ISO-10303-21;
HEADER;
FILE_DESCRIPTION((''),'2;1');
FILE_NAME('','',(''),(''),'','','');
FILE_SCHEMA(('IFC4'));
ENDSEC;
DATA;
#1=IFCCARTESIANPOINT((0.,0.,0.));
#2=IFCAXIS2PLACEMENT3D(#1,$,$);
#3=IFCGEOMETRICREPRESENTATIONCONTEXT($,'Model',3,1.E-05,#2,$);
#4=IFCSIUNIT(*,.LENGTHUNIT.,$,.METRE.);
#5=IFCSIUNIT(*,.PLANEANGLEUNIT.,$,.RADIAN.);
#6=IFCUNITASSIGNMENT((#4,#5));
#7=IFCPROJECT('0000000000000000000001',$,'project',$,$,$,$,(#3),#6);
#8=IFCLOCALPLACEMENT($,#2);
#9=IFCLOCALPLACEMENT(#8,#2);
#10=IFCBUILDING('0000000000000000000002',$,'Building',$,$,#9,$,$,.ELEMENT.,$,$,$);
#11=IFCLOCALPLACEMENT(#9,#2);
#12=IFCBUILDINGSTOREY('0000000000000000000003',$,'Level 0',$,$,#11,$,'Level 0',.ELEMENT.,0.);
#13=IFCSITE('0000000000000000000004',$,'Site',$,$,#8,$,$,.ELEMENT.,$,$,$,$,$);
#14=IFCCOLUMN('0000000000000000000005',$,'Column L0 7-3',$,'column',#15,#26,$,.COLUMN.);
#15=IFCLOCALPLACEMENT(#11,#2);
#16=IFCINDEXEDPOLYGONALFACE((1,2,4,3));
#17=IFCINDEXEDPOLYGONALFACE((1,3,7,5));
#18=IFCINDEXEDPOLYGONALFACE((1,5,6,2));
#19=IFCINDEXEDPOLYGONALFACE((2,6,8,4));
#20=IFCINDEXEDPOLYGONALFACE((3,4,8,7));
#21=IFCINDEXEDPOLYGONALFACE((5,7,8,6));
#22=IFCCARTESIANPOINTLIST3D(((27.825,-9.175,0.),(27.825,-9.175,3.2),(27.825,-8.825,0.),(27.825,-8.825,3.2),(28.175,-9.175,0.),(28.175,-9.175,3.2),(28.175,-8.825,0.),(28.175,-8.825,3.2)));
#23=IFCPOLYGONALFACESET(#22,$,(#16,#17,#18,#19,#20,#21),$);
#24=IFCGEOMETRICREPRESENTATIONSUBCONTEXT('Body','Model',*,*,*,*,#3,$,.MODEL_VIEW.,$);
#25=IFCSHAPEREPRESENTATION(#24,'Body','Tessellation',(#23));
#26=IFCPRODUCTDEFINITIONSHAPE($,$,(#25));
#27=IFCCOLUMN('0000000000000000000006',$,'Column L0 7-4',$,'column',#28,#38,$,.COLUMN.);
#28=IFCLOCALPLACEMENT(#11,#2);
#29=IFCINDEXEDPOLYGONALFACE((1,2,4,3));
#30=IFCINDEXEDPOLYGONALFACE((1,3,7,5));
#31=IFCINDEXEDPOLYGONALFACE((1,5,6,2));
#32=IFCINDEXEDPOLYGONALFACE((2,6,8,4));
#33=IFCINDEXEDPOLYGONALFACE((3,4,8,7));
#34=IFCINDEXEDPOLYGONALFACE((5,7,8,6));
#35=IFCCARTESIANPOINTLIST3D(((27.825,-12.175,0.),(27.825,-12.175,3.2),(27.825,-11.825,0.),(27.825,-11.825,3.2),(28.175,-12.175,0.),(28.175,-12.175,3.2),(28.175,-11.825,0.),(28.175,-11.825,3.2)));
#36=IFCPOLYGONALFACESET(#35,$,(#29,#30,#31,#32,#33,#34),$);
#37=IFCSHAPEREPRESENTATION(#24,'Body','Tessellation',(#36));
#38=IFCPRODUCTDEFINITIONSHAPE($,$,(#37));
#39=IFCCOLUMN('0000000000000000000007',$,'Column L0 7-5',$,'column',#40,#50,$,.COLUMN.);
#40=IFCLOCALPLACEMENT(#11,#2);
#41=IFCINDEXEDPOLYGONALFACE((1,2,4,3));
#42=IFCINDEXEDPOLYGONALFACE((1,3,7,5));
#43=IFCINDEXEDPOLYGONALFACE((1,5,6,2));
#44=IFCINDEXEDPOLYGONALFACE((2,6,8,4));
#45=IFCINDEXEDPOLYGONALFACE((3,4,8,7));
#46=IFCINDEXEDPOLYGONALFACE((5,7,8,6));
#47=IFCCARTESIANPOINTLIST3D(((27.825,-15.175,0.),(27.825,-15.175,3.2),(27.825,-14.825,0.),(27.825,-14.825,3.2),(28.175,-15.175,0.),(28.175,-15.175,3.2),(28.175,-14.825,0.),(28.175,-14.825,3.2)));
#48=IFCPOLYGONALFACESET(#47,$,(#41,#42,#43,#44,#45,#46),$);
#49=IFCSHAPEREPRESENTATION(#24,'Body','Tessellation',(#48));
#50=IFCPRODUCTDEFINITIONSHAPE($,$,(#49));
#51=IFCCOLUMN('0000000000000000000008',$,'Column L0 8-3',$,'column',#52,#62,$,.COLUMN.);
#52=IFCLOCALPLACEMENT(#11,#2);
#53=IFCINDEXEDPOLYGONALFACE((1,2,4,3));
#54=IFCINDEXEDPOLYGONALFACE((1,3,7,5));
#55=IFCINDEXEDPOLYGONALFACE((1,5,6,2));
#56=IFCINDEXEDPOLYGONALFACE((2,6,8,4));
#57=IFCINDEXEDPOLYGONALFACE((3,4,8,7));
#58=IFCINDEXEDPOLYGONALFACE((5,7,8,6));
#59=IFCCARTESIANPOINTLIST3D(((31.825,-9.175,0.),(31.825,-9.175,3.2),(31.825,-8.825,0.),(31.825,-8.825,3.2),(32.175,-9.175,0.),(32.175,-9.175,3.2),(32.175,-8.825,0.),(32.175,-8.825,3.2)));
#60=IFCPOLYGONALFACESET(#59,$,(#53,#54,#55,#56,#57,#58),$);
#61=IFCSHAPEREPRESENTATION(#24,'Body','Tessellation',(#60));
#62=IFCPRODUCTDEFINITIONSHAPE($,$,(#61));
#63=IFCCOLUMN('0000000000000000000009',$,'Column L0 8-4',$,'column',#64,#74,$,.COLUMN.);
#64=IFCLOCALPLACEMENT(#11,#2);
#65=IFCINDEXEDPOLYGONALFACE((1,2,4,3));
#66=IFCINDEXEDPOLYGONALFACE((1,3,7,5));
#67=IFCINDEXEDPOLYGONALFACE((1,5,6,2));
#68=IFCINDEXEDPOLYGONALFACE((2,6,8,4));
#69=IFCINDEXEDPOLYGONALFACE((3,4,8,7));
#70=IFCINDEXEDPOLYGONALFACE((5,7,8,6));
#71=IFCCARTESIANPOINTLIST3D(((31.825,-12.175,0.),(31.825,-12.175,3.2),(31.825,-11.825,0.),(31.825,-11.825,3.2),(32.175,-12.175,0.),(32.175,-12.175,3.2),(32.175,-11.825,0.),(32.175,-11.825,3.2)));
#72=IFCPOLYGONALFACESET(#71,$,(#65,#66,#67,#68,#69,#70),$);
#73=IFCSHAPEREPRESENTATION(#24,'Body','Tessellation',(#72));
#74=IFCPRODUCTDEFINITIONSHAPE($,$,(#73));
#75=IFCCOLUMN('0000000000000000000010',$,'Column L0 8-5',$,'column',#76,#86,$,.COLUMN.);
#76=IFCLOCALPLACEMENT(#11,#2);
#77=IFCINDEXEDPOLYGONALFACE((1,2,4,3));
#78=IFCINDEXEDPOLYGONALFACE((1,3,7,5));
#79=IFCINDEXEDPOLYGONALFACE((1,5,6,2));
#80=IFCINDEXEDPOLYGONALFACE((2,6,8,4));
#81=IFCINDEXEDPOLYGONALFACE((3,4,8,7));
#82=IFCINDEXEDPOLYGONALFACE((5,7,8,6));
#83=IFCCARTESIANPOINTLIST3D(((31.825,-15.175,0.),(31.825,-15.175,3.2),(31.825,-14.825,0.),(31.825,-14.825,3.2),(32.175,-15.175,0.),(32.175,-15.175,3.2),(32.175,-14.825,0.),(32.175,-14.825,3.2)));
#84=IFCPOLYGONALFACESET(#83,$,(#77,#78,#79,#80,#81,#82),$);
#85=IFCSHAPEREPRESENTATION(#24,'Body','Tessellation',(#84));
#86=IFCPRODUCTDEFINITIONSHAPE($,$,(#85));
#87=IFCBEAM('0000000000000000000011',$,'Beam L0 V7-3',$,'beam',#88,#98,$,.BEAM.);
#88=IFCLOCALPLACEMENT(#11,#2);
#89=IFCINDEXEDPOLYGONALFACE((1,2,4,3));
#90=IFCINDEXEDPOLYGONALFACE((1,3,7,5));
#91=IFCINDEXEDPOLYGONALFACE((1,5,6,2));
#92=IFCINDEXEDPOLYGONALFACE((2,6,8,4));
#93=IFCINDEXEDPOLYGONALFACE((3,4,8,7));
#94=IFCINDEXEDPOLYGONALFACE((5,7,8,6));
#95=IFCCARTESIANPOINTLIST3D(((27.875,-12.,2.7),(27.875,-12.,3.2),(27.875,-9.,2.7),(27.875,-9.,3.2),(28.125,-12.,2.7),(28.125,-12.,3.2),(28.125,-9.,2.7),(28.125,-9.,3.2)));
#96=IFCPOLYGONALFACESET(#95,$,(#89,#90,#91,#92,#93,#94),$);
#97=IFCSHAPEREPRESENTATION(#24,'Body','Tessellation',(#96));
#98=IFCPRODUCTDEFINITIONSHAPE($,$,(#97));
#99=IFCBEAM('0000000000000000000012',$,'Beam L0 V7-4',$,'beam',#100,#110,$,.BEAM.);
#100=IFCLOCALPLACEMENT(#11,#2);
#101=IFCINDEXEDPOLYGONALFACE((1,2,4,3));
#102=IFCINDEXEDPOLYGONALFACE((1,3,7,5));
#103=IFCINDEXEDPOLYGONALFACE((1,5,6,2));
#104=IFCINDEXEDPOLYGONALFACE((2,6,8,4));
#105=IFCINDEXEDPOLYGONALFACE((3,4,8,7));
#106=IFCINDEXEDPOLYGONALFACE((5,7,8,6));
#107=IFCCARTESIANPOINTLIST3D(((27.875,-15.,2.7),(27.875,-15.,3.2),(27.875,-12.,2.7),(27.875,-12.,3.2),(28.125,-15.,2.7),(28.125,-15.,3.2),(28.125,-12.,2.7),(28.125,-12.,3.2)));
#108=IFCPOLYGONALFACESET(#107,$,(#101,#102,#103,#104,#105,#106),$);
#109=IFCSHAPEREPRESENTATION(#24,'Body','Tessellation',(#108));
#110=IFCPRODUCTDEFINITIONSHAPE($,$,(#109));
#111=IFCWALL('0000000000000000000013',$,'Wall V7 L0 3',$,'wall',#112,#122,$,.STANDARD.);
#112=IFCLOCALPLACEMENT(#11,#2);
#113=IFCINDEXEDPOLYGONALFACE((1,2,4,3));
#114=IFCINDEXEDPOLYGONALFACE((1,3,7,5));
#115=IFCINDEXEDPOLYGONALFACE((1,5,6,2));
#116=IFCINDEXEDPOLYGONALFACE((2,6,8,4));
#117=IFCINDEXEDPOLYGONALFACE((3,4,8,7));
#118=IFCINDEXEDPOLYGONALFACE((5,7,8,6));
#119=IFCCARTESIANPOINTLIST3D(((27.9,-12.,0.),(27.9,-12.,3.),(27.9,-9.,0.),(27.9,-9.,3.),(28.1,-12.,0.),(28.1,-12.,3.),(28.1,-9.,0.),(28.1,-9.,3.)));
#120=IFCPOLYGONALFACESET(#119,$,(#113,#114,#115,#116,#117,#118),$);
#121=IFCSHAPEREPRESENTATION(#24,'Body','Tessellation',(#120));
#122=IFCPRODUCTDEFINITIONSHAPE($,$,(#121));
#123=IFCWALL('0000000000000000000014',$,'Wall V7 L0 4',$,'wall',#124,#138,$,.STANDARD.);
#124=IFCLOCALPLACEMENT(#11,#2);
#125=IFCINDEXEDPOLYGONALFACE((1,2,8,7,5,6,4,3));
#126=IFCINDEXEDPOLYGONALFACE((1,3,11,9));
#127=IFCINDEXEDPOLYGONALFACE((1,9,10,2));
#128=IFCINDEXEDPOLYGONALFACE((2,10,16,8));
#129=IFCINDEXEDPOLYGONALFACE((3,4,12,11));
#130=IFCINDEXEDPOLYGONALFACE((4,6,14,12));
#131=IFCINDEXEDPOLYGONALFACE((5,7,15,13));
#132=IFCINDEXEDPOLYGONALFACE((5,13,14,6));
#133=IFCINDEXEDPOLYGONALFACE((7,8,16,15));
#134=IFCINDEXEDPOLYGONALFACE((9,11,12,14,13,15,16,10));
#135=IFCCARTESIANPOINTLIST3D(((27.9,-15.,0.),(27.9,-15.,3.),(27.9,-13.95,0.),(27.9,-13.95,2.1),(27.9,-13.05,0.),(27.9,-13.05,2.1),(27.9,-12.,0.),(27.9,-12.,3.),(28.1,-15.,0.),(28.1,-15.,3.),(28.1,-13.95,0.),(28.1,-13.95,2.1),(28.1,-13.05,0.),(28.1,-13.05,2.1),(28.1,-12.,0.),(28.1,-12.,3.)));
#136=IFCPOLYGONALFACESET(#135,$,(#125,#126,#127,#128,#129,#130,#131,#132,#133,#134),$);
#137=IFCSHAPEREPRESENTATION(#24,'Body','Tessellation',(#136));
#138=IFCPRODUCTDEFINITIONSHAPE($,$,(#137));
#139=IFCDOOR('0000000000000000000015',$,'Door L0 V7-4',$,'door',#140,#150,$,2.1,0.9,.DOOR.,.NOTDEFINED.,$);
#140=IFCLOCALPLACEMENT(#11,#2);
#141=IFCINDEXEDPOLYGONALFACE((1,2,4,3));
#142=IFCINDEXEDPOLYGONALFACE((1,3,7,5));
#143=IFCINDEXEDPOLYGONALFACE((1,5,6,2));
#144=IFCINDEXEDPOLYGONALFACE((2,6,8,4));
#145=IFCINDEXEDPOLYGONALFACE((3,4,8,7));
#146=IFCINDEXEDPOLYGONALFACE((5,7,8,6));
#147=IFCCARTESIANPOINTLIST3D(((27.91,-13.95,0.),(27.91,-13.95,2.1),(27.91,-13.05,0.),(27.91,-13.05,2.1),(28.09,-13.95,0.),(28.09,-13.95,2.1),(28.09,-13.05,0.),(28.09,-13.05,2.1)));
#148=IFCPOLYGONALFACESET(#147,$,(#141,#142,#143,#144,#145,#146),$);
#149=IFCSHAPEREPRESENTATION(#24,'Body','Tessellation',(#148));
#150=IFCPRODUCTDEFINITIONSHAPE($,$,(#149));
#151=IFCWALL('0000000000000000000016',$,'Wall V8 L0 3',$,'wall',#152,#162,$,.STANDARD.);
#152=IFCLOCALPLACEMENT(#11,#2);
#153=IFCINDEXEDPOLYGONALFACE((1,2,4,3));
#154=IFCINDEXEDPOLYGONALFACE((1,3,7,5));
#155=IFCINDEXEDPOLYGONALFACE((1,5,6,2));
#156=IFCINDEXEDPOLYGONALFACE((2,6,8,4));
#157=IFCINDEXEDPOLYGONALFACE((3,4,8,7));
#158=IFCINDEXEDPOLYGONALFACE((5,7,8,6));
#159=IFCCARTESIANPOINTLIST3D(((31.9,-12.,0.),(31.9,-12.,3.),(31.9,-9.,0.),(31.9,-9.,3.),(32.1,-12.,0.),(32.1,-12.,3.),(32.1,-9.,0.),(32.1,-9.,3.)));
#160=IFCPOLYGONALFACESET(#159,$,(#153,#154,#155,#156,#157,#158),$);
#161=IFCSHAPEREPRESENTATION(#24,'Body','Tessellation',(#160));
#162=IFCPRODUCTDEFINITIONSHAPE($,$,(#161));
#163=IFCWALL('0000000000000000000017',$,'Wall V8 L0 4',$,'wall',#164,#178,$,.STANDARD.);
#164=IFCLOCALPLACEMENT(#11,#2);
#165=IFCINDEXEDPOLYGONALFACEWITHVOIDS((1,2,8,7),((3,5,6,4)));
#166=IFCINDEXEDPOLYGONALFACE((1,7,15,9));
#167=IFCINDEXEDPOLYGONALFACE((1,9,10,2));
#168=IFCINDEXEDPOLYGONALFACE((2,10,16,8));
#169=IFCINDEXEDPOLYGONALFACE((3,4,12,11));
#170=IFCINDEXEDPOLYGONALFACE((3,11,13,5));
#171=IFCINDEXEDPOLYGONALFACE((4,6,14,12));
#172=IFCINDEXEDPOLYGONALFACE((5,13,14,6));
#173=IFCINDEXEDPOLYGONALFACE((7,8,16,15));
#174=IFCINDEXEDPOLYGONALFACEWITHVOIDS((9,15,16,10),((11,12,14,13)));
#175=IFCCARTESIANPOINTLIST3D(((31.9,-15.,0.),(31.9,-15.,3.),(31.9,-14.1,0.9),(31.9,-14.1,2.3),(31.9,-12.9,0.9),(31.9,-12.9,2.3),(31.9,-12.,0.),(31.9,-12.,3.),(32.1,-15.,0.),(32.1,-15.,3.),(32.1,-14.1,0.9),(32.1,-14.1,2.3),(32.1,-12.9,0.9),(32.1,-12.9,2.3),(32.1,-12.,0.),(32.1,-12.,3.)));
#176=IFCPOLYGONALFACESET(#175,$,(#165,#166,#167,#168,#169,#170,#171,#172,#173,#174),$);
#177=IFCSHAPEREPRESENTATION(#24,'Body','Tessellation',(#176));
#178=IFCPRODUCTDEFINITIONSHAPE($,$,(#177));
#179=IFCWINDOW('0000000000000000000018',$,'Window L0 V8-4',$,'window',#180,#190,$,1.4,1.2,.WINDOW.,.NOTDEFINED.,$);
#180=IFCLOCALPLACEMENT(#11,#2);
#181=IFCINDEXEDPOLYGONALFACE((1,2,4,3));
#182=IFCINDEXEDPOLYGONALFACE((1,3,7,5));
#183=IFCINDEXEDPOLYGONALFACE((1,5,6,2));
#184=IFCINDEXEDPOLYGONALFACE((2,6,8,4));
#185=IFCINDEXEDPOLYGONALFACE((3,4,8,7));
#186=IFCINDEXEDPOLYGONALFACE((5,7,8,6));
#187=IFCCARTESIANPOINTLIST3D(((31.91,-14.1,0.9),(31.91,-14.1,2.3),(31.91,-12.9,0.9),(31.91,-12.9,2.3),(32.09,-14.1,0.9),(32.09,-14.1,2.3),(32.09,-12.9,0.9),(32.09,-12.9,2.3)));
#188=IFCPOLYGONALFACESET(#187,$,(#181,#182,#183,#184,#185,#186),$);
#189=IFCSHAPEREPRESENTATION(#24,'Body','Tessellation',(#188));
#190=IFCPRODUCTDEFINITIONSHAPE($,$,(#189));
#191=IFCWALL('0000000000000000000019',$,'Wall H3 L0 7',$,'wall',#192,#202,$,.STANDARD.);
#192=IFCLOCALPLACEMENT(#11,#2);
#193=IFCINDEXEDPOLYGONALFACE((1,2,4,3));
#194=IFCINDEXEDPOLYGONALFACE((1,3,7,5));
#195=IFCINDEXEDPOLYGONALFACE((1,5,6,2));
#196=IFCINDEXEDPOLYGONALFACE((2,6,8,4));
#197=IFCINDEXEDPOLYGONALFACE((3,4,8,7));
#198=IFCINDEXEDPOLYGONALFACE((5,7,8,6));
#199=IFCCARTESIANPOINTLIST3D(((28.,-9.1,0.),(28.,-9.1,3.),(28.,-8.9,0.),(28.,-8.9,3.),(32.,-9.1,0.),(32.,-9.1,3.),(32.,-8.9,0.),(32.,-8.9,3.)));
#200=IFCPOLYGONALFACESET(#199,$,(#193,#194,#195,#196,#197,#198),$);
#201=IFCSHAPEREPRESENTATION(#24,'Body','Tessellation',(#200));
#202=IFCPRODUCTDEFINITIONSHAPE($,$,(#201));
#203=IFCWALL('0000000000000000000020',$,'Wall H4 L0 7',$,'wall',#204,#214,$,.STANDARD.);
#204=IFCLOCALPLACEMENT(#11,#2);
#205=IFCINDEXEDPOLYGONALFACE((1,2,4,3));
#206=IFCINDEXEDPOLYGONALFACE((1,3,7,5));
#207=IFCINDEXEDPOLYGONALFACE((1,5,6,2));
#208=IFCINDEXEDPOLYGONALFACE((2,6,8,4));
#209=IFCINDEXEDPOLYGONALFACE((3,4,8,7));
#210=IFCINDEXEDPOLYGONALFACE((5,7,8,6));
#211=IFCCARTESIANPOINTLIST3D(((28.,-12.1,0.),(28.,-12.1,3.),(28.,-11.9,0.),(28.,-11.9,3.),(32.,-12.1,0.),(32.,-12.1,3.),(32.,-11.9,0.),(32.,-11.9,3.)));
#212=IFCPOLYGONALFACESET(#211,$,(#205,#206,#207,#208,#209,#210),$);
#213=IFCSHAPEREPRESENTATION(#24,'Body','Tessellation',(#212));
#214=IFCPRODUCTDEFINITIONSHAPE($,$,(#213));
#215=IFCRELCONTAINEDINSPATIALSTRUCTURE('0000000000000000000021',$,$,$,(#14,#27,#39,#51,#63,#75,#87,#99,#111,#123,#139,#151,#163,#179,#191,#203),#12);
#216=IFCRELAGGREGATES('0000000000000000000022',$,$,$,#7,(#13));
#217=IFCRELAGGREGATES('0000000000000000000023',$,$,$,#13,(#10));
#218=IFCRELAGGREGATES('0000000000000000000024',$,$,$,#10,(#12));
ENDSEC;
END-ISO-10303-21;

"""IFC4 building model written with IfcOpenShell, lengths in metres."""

from ifc_helpers import new_model, si_unit, frame, frame_2d, origin, origin_2d, place, context, subcontext, project, spatial, rectangle, extrude, element, fill, save


model = new_model("IFC4")

# Units and contexts
model_context = context("Model", 3, precision=1e-05, world=origin())
body_context = subcontext(model_context, "Body", "Model", "MODEL_VIEW")
ifc_project = project(units=[si_unit("LENGTHUNIT", "METRE"), si_unit("PLANEANGLEUNIT", "RADIAN")], contexts=[model_context])

# Site, building, storey
site_placement = place(None, origin())
site = spatial("IfcSite", under=ifc_project, at=site_placement, Name="Site", CompositionType="ELEMENT")
building_placement = place(site_placement, origin())
building = spatial("IfcBuilding", under=site, at=building_placement, Name="Building", CompositionType="ELEMENT")
storey_placement = place(building_placement, origin())
storey = spatial("IfcBuildingStorey", under=building, at=storey_placement, Name="Level 0", LongName="Level 0", CompositionType="ELEMENT", Elevation=0.0)

# Columns
for number, where, name in (
    (1, (28.0, -9.0, 0.0), "Column L0 7-3"),
    (2, (28.0, -12.0, 0.0), "Column L0 7-4"),
    (3, (28.0, -15.0, 0.0), "Column L0 7-5"),
    (4, (32.0, -9.0, 0.0), "Column L0 8-3"),
    (5, (32.0, -12.0, 0.0), "Column L0 8-4"),
    (6, (32.0, -15.0, 0.0), "Column L0 8-5"),
):
    element("IfcColumn", number, at=place(storey_placement, frame(where)), inside=storey, Name=name, ObjectType="column", PredefinedType="COLUMN", context=body_context, shape_type="SweptSolid", body=[
        extrude(rectangle(XDim=0.35, YDim=0.35, at=origin_2d()), origin(), (0.0, 0.0, 1.0), 3.2),
    ])

# Beams
for number, where, z_axis, x_axis, name in (
    (7, (28.0, -9.0, 2.95), (0.0, -1.0, 0.0), (0.0, 0.0, 1.0), "Beam L0 V7-3"),
    (8, (28.0, -12.0, 2.95), (0.0, -1.0, 0.0), (0.0, 0.0, 1.0), "Beam L0 V7-4"),
):
    element("IfcBeam", number, at=place(storey_placement, frame(where, z_axis=z_axis, x_axis=x_axis)), inside=storey, Name=name, ObjectType="beam", PredefinedType="BEAM", context=body_context, shape_type="SweptSolid", body=[
        extrude(rectangle(XDim=0.5, YDim=0.25, at=origin_2d()), origin(), (0.0, 0.0, 1.0), 3.0),
    ])

# Wall
wall_1_placement = place(storey_placement, frame((28.0, -9.0, 0.0), z_axis=(0.0, 0.0, 1.0), x_axis=(0.0, -1.0, 0.0)))
element("IfcWall", 9, at=wall_1_placement, inside=storey, Name="Wall V7 L0 3", ObjectType="wall", PredefinedType="STANDARD", context=body_context, shape_type="SweptSolid", body=[
    extrude(rectangle(XDim=3.0, YDim=0.2, at=frame_2d((1.5, 0.0))), origin(), (0.0, 0.0, 1.0), 3.0),
])

# Wall, opening, door
wall_2_placement = place(storey_placement, frame((28.0, -12.0, 0.0), z_axis=(0.0, 0.0, 1.0), x_axis=(0.0, -1.0, 0.0)))
wall_2 = element("IfcWall", 10, at=wall_2_placement, inside=storey, Name="Wall V7 L0 4", ObjectType="wall", PredefinedType="STANDARD", context=body_context, shape_type="SweptSolid", body=[
    extrude(rectangle(XDim=3.0, YDim=0.2, at=frame_2d((1.5, 0.0))), origin(), (0.0, 0.0, 1.0), 3.0),
])
opening_1_placement = place(storey_placement, frame((28.0, -13.5, 0.0), z_axis=(0.0, 0.0, 1.0), x_axis=(0.0, -1.0, 0.0)))
opening_1 = element("IfcOpeningElement", 11, at=opening_1_placement, cuts=wall_2, ObjectType="Opening", PredefinedType="OPENING", context=body_context, shape_type="SweptSolid", body=[
    extrude(rectangle(XDim=0.9, YDim=0.22, at=origin_2d()), origin(), (0.0, 0.0, 1.0), 2.1),
])
door_placement = place(storey_placement, frame((28.0, -13.5, 0.0), z_axis=(0.0, 0.0, 1.0), x_axis=(0.0, -1.0, 0.0)))
door = element("IfcDoor", 12, at=door_placement, inside=storey, Name="Door L0 V7-4", ObjectType="door", OperationType="NOTDEFINED", OverallHeight=2.1, OverallWidth=0.9, PredefinedType="DOOR", context=body_context, shape_type="SweptSolid", body=[
    extrude(rectangle(XDim=0.9, YDim=0.18, at=origin_2d()), origin(), (0.0, 0.0, 1.0), 2.1),
])
fill(opening_1, door)

# Wall
wall_3_placement = place(storey_placement, frame((32.0, -9.0, 0.0), z_axis=(0.0, 0.0, 1.0), x_axis=(0.0, -1.0, 0.0)))
element("IfcWall", 13, at=wall_3_placement, inside=storey, Name="Wall V8 L0 3", ObjectType="wall", PredefinedType="STANDARD", context=body_context, shape_type="SweptSolid", body=[
    extrude(rectangle(XDim=3.0, YDim=0.2, at=frame_2d((1.5, 0.0))), origin(), (0.0, 0.0, 1.0), 3.0),
])

# Wall, opening, window
wall_4_placement = place(storey_placement, frame((32.0, -12.0, 0.0), z_axis=(0.0, 0.0, 1.0), x_axis=(0.0, -1.0, 0.0)))
wall_4 = element("IfcWall", 14, at=wall_4_placement, inside=storey, Name="Wall V8 L0 4", ObjectType="wall", PredefinedType="STANDARD", context=body_context, shape_type="SweptSolid", body=[
    extrude(rectangle(XDim=3.0, YDim=0.2, at=frame_2d((1.5, 0.0))), origin(), (0.0, 0.0, 1.0), 3.0),
])
opening_2_placement = place(storey_placement, frame((32.0, -13.5, 0.9), z_axis=(0.0, 0.0, 1.0), x_axis=(0.0, -1.0, 0.0)))
opening_2 = element("IfcOpeningElement", 15, at=opening_2_placement, cuts=wall_4, ObjectType="Opening", PredefinedType="OPENING", context=body_context, shape_type="SweptSolid", body=[
    extrude(rectangle(XDim=1.2, YDim=0.22, at=origin_2d()), origin(), (0.0, 0.0, 1.0), 1.4),
])
window_placement = place(storey_placement, frame((32.0, -13.5, 0.9), z_axis=(0.0, 0.0, 1.0), x_axis=(0.0, -1.0, 0.0)))
window = element("IfcWindow", 16, at=window_placement, inside=storey, Name="Window L0 V8-4", ObjectType="window", OverallHeight=1.4, OverallWidth=1.2, PartitioningType="NOTDEFINED", PredefinedType="WINDOW", context=body_context, shape_type="SweptSolid", body=[
    extrude(rectangle(XDim=1.2, YDim=0.18, at=origin_2d()), origin(), (0.0, 0.0, 1.0), 1.4),
])
fill(opening_2, window)

# Walls
for number, where, z_axis, x_axis, name in (
    (17, (28.0, -9.0, 0.0), (0.0, 0.0, 1.0), (1.0, 0.0, 0.0), "Wall H3 L0 7"),
    (18, (28.0, -12.0, 0.0), (0.0, 0.0, 1.0), (1.0, 0.0, 0.0), "Wall H4 L0 7"),
):
    element("IfcWall", number, at=place(storey_placement, frame(where, z_axis=z_axis, x_axis=x_axis)), inside=storey, Name=name, ObjectType="wall", PredefinedType="STANDARD", context=body_context, shape_type="SweptSolid", body=[
        extrude(rectangle(XDim=4.0, YDim=0.2, at=frame_2d((2.0, 0.0))), origin(), (0.0, 0.0, 1.0), 3.0),
    ])

save(model, "model.ifc")
